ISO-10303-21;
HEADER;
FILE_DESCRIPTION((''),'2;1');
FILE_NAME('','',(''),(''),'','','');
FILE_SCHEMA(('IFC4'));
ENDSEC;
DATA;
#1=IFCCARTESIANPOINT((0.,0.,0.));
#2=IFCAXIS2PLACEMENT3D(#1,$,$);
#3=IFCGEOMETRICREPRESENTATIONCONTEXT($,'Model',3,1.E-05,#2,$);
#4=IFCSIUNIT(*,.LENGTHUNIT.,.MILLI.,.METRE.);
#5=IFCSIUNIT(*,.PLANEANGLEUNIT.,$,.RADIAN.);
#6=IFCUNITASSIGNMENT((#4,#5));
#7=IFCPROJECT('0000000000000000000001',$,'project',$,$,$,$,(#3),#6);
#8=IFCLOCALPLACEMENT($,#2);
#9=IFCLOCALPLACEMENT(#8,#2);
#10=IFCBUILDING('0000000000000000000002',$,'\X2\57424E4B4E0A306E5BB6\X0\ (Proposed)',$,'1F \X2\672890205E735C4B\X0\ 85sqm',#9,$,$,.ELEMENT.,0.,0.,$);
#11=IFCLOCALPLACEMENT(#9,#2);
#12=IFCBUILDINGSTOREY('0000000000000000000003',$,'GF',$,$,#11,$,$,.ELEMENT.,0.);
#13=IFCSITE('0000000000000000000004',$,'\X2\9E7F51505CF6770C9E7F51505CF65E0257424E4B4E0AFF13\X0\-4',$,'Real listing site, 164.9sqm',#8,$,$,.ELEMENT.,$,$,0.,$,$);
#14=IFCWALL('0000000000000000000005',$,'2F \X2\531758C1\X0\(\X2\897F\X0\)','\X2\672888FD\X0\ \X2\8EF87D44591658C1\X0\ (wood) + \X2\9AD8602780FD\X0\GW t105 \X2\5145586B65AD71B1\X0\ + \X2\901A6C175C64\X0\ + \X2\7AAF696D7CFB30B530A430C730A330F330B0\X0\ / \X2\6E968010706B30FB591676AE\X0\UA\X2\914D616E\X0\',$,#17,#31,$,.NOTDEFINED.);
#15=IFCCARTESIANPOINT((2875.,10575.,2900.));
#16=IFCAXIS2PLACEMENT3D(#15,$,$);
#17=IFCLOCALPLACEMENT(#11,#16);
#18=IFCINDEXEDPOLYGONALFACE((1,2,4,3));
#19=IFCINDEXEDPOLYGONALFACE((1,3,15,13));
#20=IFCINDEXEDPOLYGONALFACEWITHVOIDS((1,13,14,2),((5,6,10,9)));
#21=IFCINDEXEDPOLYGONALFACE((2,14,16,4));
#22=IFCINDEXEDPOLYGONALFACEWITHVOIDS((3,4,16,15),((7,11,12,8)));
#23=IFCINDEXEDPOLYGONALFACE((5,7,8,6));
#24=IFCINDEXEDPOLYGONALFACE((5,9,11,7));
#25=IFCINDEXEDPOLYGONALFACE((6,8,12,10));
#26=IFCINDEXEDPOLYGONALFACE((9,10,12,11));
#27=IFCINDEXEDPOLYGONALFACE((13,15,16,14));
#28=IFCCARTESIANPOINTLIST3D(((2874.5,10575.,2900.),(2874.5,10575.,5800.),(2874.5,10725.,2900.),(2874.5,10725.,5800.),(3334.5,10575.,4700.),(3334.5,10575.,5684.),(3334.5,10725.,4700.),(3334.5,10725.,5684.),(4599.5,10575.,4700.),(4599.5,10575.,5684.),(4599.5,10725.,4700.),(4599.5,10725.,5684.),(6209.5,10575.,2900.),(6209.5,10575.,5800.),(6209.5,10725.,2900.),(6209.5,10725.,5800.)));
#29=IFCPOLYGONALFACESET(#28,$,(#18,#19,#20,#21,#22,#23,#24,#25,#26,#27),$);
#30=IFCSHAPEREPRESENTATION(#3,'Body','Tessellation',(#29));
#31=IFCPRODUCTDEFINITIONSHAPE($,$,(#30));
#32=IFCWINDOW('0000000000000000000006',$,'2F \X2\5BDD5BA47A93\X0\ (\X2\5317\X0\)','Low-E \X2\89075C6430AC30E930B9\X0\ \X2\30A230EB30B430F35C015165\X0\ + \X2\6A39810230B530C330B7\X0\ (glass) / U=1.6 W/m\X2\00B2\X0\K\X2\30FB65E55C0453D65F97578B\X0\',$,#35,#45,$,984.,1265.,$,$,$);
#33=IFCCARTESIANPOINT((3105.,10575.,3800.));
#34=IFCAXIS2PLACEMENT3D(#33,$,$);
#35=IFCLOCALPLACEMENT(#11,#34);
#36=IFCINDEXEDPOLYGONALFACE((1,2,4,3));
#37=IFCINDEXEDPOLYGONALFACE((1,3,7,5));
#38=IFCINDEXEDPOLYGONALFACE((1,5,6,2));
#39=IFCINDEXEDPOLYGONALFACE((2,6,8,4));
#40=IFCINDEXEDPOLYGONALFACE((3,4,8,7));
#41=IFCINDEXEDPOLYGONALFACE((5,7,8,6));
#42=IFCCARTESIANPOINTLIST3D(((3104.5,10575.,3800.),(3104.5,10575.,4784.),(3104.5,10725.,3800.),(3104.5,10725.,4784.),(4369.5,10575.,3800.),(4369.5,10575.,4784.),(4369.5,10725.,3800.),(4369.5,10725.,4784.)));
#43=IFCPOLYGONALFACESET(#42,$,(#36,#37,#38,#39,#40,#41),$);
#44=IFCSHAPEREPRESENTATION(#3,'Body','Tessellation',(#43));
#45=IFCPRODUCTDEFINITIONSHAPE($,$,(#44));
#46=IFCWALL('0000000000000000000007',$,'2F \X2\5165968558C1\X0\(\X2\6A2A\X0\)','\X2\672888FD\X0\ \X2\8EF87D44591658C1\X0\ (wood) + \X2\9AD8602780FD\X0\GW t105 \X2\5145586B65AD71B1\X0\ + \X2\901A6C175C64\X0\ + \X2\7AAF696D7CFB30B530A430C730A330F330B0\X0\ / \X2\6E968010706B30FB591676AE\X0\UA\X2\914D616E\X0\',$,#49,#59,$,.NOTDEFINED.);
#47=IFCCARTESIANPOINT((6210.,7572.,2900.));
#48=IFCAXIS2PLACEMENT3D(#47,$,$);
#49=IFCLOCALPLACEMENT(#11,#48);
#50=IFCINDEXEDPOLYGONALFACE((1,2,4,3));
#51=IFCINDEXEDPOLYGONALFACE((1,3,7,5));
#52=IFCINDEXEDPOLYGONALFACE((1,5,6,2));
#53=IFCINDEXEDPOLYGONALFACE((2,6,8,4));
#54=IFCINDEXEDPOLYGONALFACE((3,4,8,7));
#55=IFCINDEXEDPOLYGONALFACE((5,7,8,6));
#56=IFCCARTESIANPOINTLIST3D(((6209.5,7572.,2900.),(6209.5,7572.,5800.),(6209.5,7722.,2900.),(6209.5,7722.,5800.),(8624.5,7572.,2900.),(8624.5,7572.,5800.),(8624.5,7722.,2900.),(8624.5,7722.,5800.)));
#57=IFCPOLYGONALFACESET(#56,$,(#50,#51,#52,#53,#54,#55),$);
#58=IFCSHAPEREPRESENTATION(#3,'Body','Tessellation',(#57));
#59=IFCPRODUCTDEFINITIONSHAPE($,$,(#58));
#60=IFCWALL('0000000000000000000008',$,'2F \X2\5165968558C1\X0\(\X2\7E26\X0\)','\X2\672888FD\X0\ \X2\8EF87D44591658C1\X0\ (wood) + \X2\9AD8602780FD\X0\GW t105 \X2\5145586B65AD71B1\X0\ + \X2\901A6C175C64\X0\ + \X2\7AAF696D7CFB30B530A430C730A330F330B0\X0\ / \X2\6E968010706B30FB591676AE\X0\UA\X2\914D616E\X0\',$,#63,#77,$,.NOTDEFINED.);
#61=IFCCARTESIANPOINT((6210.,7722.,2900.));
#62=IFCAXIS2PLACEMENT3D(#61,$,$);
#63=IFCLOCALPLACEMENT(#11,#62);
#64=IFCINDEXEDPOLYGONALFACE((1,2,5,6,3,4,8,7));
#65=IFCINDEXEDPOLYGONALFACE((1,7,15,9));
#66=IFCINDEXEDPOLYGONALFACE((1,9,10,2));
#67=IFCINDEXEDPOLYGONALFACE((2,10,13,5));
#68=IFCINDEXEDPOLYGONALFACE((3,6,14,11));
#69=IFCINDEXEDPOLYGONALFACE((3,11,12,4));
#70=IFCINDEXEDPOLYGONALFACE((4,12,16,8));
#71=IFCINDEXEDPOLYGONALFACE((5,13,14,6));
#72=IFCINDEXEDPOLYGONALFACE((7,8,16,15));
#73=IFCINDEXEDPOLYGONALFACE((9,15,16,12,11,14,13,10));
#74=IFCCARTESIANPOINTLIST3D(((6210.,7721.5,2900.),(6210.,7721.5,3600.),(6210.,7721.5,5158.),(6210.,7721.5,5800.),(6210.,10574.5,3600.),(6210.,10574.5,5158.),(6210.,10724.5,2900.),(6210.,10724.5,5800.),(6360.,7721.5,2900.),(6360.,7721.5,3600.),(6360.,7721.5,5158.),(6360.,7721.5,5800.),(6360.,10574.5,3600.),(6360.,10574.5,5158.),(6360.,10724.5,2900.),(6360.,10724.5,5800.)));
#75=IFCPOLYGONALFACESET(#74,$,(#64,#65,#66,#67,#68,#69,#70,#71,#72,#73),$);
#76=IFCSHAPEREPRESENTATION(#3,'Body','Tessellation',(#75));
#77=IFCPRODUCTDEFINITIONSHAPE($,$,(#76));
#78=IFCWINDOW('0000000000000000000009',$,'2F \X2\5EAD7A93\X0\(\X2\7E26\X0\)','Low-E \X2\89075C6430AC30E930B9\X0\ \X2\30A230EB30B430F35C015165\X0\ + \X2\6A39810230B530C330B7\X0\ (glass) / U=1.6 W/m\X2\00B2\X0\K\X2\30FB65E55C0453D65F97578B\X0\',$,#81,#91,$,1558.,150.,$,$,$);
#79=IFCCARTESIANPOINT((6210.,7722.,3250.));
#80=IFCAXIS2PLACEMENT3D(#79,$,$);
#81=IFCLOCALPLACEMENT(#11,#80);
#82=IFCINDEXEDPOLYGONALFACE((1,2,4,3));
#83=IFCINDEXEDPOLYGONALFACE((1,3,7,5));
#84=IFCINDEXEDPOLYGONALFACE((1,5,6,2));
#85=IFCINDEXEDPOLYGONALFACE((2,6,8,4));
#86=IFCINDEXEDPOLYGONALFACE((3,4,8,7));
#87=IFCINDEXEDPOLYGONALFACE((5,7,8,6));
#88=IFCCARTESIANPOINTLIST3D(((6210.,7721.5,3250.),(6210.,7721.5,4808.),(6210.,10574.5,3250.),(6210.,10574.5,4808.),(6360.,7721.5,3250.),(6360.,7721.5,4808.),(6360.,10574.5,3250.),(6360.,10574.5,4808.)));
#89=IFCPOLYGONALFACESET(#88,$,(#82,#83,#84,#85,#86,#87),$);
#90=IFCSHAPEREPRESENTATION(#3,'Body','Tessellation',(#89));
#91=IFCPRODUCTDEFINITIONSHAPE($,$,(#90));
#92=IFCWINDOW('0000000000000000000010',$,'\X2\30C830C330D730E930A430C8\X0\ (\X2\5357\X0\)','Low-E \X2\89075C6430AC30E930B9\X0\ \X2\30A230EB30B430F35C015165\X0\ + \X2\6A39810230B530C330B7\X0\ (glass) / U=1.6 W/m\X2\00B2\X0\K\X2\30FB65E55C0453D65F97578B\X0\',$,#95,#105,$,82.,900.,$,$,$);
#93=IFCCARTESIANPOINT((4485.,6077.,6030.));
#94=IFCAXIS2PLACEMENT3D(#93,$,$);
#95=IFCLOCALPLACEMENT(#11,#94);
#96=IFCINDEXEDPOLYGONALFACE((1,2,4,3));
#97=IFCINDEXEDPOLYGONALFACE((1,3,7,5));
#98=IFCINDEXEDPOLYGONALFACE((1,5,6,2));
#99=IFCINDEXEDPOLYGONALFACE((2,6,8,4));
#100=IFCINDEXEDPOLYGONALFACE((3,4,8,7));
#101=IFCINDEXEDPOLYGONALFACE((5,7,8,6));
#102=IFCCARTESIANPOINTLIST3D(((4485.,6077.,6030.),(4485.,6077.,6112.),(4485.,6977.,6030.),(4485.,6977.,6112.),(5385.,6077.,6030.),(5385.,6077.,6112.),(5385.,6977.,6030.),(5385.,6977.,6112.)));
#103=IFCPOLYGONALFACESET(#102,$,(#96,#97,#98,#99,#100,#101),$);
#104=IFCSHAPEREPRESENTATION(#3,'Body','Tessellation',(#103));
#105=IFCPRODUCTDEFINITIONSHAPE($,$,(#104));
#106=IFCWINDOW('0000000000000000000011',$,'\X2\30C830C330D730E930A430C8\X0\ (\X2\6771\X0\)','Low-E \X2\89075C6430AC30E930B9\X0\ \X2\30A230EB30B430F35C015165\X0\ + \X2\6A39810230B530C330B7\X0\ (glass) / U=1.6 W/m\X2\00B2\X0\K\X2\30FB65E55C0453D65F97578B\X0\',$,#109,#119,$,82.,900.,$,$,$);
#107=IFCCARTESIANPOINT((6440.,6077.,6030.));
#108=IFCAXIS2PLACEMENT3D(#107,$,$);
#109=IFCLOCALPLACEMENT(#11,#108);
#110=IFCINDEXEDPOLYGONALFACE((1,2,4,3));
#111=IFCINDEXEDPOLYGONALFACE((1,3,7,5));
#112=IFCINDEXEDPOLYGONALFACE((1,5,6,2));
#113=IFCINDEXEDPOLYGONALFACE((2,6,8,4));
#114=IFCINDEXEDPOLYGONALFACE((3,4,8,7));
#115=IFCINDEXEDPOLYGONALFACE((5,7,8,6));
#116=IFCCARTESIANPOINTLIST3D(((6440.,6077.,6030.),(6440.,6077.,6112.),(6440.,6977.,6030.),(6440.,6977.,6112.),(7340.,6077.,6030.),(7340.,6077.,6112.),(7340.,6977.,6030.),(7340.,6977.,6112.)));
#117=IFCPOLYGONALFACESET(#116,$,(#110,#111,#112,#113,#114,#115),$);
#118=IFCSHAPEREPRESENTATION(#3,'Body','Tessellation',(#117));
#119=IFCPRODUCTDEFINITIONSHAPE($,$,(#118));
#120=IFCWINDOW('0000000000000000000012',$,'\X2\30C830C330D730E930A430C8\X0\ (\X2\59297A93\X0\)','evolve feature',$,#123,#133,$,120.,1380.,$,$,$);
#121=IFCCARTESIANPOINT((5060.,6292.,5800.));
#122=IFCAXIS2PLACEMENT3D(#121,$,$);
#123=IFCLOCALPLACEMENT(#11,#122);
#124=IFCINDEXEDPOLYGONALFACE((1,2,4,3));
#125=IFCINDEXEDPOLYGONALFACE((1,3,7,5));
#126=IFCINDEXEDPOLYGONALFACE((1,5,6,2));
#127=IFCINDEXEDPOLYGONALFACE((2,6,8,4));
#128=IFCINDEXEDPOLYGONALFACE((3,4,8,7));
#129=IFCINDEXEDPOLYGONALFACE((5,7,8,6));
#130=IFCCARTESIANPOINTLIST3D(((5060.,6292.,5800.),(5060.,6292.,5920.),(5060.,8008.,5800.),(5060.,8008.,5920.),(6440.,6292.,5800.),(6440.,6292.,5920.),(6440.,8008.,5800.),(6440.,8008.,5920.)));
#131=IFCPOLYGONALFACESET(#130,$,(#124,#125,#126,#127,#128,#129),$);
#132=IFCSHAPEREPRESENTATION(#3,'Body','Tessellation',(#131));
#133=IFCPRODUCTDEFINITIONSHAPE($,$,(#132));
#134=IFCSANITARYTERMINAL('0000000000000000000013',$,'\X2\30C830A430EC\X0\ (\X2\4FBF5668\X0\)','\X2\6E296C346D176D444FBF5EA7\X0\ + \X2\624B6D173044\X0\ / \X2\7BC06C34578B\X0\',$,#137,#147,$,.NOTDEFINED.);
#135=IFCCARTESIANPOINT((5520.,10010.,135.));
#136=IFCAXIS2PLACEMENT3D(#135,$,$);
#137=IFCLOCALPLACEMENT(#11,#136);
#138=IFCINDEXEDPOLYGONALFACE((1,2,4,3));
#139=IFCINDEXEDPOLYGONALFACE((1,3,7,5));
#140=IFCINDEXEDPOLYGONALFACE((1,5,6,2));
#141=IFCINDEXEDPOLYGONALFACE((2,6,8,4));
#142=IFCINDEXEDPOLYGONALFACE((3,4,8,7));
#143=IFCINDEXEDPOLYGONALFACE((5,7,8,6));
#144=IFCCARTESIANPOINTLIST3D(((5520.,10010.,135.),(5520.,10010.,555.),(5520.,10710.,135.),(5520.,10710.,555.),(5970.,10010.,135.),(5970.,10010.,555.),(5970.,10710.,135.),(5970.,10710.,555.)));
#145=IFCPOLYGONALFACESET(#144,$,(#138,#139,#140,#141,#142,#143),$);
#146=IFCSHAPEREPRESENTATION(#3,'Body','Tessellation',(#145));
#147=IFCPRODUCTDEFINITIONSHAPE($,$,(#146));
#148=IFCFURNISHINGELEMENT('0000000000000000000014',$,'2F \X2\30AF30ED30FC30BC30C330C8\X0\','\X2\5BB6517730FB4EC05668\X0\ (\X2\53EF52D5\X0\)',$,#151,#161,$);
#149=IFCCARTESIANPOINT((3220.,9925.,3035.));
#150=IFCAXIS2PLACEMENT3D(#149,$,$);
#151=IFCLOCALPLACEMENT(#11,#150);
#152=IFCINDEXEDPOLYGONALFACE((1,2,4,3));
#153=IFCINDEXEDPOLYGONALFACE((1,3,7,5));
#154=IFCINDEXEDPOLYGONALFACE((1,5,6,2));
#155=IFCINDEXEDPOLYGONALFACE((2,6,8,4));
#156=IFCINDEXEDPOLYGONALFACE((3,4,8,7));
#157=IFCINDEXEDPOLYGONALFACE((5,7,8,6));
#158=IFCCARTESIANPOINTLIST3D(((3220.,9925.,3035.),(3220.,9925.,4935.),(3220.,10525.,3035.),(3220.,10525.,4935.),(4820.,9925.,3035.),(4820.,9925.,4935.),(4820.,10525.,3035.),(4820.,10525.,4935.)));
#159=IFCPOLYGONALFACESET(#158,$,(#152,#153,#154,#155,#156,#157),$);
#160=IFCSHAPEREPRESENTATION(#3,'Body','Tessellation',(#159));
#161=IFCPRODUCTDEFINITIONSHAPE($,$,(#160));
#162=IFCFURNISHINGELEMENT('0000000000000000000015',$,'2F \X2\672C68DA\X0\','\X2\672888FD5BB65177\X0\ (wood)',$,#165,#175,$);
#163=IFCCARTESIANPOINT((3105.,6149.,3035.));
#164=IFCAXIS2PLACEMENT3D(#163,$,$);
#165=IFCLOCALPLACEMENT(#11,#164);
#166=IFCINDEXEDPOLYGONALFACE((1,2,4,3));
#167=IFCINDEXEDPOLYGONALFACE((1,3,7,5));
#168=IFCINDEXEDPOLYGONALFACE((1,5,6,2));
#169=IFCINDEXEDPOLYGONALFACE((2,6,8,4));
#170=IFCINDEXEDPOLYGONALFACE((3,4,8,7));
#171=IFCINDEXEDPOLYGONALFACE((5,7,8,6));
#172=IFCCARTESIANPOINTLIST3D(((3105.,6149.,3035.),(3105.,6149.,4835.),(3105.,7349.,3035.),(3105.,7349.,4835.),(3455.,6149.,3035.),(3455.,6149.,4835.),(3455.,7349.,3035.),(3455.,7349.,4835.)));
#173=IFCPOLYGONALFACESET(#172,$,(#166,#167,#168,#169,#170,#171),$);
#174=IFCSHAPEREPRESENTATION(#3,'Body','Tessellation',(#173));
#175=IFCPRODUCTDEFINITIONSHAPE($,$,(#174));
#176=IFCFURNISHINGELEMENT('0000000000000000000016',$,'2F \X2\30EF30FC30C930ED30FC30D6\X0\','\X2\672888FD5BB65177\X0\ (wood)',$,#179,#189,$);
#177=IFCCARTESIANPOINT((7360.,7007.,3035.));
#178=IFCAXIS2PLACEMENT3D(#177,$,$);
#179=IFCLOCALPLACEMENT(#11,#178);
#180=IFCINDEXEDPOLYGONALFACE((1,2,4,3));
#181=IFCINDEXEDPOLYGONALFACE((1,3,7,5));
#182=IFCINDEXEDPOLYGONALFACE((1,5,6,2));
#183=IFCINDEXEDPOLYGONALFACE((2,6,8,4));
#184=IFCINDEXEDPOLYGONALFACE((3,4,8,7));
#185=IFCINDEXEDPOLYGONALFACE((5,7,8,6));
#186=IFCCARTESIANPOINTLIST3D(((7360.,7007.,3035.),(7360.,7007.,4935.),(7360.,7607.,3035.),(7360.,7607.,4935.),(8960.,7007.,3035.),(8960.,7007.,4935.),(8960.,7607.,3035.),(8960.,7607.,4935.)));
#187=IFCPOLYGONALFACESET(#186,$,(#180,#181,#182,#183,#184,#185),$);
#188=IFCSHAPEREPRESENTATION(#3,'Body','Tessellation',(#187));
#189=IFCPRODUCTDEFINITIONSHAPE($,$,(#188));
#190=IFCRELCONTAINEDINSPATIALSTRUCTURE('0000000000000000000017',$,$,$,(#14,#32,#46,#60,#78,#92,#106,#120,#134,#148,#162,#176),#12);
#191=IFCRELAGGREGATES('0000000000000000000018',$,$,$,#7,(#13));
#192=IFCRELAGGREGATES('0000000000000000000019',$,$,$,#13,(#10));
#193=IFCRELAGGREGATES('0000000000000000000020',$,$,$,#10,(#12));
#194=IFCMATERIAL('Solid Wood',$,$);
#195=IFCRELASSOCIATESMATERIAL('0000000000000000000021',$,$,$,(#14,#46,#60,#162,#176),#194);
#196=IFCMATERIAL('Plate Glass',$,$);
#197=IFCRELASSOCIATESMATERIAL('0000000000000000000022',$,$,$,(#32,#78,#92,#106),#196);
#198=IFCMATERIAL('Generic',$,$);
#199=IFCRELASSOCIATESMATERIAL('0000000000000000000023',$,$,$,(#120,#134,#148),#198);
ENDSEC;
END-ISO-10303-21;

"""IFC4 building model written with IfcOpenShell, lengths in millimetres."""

from ifc_helpers import new_model, si_unit, frame, frame_2d, origin, place, context, project, spatial, rectangle, extrude, material, element, fill, save


model = new_model("IFC4")

# Units and contexts
model_context = context("Model", 3, precision=1e-05, world=origin())
ifc_project = project(units=[si_unit("LENGTHUNIT", "METRE", prefix="MILLI"), si_unit("PLANEANGLEUNIT", "RADIAN")], contexts=[model_context])

# Site, building, storey
site_placement = place(None, origin())
site = spatial("IfcSite", under=ifc_project, at=site_placement, Name="鹿児島県鹿児島市坂之上３-4", ObjectType="Real listing site, 164.9sqm", CompositionType="ELEMENT", RefElevation=0.0)
building_placement = place(site_placement, origin())
building = spatial("IfcBuilding", under=site, at=building_placement, Name="坂之上の家 (Proposed)", ObjectType="1F 木造平屋 85sqm", CompositionType="ELEMENT", ElevationOfRefHeight=0.0, ElevationOfTerrain=0.0)
storey_placement = place(building_placement, origin())
storey = spatial("IfcBuildingStorey", under=building, at=storey_placement, Name="GF", CompositionType="ELEMENT", Elevation=0.0)

# Shared definitions
ifc_material_1 = material(Name="Solid Wood")

# Wall, opening, window
wall_1_placement = place(storey_placement, frame((2875.0, 10575.0, 2900.0)))
wall_1 = element("IfcWall", 1, at=wall_1_placement, inside=storey, material=ifc_material_1, Name="2F 北壁(西)", Description="木製 軸組外壁 (wood) + 高性能GW t105 充填断熱 + 通気層 + 窯業系サイディング / 準耐火・外皮UA配慮", PredefinedType="NOTDEFINED", context=model_context, shape_type="SweptSolid", body=[
    extrude(rectangle(XDim=3335.0, YDim=150.0, at=frame_2d((1667.0, 75.0))), frame((2875.0, 10575.0, 2900.0)), (0.0, 0.0, 1.0), 2900.0),
])
opening_1_placement = place(storey_placement, frame((3105.0, 10575.0, 3800.0)))
opening_1 = element("IfcOpeningElement", 2, at=opening_1_placement, cuts=wall_1, PredefinedType="NOTDEFINED", context=model_context, shape_type="SweptSolid", body=[
    extrude(rectangle(XDim=1265.0, YDim=150.0, at=frame_2d((632.0, 75.0))), frame((3105.0, 10575.0, 3800.0)), (0.0, 0.0, 1.0), 984.0),
])
ifc_material_2 = material(Name="Plate Glass")
window_1_placement = place(storey_placement, frame((3105.0, 10575.0, 3800.0)))
window_1 = element("IfcWindow", 3, at=window_1_placement, inside=storey, material=ifc_material_2, Name="2F 寝室窓 (北)", Description="Low-E 複層ガラス アルゴン封入 + 樹脂サッシ (glass) / U=1.6 W/m²K・日射取得型", OverallHeight=984.0, OverallWidth=1265.0, context=model_context, shape_type="SweptSolid", body=[
    extrude(rectangle(XDim=1265.0, YDim=150.0, at=frame_2d((632.0, 75.0))), frame((3105.0, 10575.0, 3800.0)), (0.0, 0.0, 1.0), 984.0),
])
fill(opening_1, window_1)

# Wall
wall_2_placement = place(storey_placement, frame((6210.0, 7572.0, 2900.0)))
element("IfcWall", 4, at=wall_2_placement, inside=storey, material=ifc_material_1, Name="2F 入隅壁(横)", Description="木製 軸組外壁 (wood) + 高性能GW t105 充填断熱 + 通気層 + 窯業系サイディング / 準耐火・外皮UA配慮", PredefinedType="NOTDEFINED", context=model_context, shape_type="SweptSolid", body=[
    extrude(rectangle(XDim=2415.0, YDim=150.0, at=frame_2d((1207.0, 75.0))), frame((6210.0, 7572.0, 2900.0)), (0.0, 0.0, 1.0), 2900.0),
])

# Wall, opening, window
wall_3_placement = place(storey_placement, frame((6210.0, 7722.0, 2900.0)))
wall_3 = element("IfcWall", 5, at=wall_3_placement, inside=storey, material=ifc_material_1, Name="2F 入隅壁(縦)", Description="木製 軸組外壁 (wood) + 高性能GW t105 充填断熱 + 通気層 + 窯業系サイディング / 準耐火・外皮UA配慮", PredefinedType="NOTDEFINED", context=model_context, shape_type="SweptSolid", body=[
    extrude(rectangle(XDim=150.0, YDim=3003.0, at=frame_2d((75.0, 1501.0))), frame((6210.0, 7722.0, 2900.0)), (0.0, 0.0, 1.0), 2900.0),
])
opening_2_placement = place(storey_placement, frame((6210.0, 7722.0, 3250.0)))
opening_2 = element("IfcOpeningElement", 6, at=opening_2_placement, cuts=wall_3, PredefinedType="NOTDEFINED", context=model_context, shape_type="SweptSolid", body=[
    extrude(rectangle(XDim=150.0, YDim=2853.0, at=frame_2d((75.0, 1426.0))), frame((6210.0, 7722.0, 3250.0)), (0.0, 0.0, 1.0), 1558.0),
])
window_2_placement = place(storey_placement, frame((6210.0, 7722.0, 3250.0)))
window_2 = element("IfcWindow", 7, at=window_2_placement, inside=storey, material=ifc_material_2, Name="2F 庭窓(縦)", Description="Low-E 複層ガラス アルゴン封入 + 樹脂サッシ (glass) / U=1.6 W/m²K・日射取得型", OverallHeight=1558.0, OverallWidth=150.0, context=model_context, shape_type="SweptSolid", body=[
    extrude(rectangle(XDim=150.0, YDim=2853.0, at=frame_2d((75.0, 1426.0))), frame((6210.0, 7722.0, 3250.0)), (0.0, 0.0, 1.0), 1558.0),
])
fill(opening_2, window_2)

# Windows
window_3_placement = place(storey_placement, frame((4485.0, 6077.0, 6030.0)))
element("IfcWindow", 8, at=window_3_placement, inside=storey, material=ifc_material_2, Name="トップライト (南)", Description="Low-E 複層ガラス アルゴン封入 + 樹脂サッシ (glass) / U=1.6 W/m²K・日射取得型", OverallHeight=82.0, OverallWidth=900.0, context=model_context, shape_type="SweptSolid", body=[
    extrude(rectangle(XDim=900.0, YDim=900.0, at=frame_2d((450.0, 450.0))), frame((4485.0, 6077.0, 6030.0)), (0.0, 0.0, 1.0), 82.0),
])
window_4_placement = place(storey_placement, frame((6440.0, 6077.0, 6030.0)))
element("IfcWindow", 9, at=window_4_placement, inside=storey, material=ifc_material_2, Name="トップライト (東)", Description="Low-E 複層ガラス アルゴン封入 + 樹脂サッシ (glass) / U=1.6 W/m²K・日射取得型", OverallHeight=82.0, OverallWidth=900.0, context=model_context, shape_type="SweptSolid", body=[
    extrude(rectangle(XDim=900.0, YDim=900.0, at=frame_2d((450.0, 450.0))), frame((6440.0, 6077.0, 6030.0)), (0.0, 0.0, 1.0), 82.0),
])
ifc_material_3 = material(Name="Generic")
window_5_placement = place(storey_placement, frame((5060.0, 6292.0, 5800.0)))
element("IfcWindow", 10, at=window_5_placement, inside=storey, material=ifc_material_3, Name="トップライト (天窓)", Description="evolve feature", OverallHeight=120.0, OverallWidth=1380.0, context=model_context, shape_type="SweptSolid", body=[
    extrude(rectangle(XDim=1380.0, YDim=1716.0, at=frame_2d((690.0, 858.0))), frame((5060.0, 6292.0, 5800.0)), (0.0, 0.0, 1.0), 120.0),
])

# Sanitary terminal
sanitary_terminal_placement = place(storey_placement, frame((5520.0, 10010.0, 135.0)))
element("IfcSanitaryTerminal", 11, at=sanitary_terminal_placement, inside=storey, material=ifc_material_3, Name="トイレ (便器)", Description="温水洗浄便座 + 手洗い / 節水型", PredefinedType="NOTDEFINED", context=model_context, shape_type="SweptSolid", body=[
    extrude(rectangle(XDim=450.0, YDim=700.0, at=frame_2d((225.0, 350.0))), frame((5520.0, 10010.0, 135.0)), (0.0, 0.0, 1.0), 420.0),
])

# Furnishing elements
furnishing_1_placement = place(storey_placement, frame((3220.0, 9925.0, 3035.0)))
element("IfcFurnishingElement", 12, at=furnishing_1_placement, inside=storey, material=ifc_material_3, Name="2F クローゼット", Description="家具・什器 (可動)", context=model_context, shape_type="SweptSolid", body=[
    extrude(rectangle(XDim=1600.0, YDim=600.0, at=frame_2d((800.0, 300.0))), frame((3220.0, 9925.0, 3035.0)), (0.0, 0.0, 1.0), 1900.0),
])
furnishing_2_placement = place(storey_placement, frame((3105.0, 6149.0, 3035.0)))
element("IfcFurnishingElement", 13, at=furnishing_2_placement, inside=storey, material=ifc_material_1, Name="2F 本棚", Description="木製家具 (wood)", context=model_context, shape_type="SweptSolid", body=[
    extrude(rectangle(XDim=350.0, YDim=1200.0, at=frame_2d((175.0, 600.0))), frame((3105.0, 6149.0, 3035.0)), (0.0, 0.0, 1.0), 1800.0),
])
furnishing_3_placement = place(storey_placement, frame((7360.0, 7007.0, 3035.0)))
element("IfcFurnishingElement", 14, at=furnishing_3_placement, inside=storey, material=ifc_material_1, Name="2F ワードローブ", Description="木製家具 (wood)", context=model_context, shape_type="SweptSolid", body=[
    extrude(rectangle(XDim=1600.0, YDim=600.0, at=frame_2d((800.0, 300.0))), frame((7360.0, 7007.0, 3035.0)), (0.0, 0.0, 1.0), 1900.0),
])

save(model, "model.ifc")
